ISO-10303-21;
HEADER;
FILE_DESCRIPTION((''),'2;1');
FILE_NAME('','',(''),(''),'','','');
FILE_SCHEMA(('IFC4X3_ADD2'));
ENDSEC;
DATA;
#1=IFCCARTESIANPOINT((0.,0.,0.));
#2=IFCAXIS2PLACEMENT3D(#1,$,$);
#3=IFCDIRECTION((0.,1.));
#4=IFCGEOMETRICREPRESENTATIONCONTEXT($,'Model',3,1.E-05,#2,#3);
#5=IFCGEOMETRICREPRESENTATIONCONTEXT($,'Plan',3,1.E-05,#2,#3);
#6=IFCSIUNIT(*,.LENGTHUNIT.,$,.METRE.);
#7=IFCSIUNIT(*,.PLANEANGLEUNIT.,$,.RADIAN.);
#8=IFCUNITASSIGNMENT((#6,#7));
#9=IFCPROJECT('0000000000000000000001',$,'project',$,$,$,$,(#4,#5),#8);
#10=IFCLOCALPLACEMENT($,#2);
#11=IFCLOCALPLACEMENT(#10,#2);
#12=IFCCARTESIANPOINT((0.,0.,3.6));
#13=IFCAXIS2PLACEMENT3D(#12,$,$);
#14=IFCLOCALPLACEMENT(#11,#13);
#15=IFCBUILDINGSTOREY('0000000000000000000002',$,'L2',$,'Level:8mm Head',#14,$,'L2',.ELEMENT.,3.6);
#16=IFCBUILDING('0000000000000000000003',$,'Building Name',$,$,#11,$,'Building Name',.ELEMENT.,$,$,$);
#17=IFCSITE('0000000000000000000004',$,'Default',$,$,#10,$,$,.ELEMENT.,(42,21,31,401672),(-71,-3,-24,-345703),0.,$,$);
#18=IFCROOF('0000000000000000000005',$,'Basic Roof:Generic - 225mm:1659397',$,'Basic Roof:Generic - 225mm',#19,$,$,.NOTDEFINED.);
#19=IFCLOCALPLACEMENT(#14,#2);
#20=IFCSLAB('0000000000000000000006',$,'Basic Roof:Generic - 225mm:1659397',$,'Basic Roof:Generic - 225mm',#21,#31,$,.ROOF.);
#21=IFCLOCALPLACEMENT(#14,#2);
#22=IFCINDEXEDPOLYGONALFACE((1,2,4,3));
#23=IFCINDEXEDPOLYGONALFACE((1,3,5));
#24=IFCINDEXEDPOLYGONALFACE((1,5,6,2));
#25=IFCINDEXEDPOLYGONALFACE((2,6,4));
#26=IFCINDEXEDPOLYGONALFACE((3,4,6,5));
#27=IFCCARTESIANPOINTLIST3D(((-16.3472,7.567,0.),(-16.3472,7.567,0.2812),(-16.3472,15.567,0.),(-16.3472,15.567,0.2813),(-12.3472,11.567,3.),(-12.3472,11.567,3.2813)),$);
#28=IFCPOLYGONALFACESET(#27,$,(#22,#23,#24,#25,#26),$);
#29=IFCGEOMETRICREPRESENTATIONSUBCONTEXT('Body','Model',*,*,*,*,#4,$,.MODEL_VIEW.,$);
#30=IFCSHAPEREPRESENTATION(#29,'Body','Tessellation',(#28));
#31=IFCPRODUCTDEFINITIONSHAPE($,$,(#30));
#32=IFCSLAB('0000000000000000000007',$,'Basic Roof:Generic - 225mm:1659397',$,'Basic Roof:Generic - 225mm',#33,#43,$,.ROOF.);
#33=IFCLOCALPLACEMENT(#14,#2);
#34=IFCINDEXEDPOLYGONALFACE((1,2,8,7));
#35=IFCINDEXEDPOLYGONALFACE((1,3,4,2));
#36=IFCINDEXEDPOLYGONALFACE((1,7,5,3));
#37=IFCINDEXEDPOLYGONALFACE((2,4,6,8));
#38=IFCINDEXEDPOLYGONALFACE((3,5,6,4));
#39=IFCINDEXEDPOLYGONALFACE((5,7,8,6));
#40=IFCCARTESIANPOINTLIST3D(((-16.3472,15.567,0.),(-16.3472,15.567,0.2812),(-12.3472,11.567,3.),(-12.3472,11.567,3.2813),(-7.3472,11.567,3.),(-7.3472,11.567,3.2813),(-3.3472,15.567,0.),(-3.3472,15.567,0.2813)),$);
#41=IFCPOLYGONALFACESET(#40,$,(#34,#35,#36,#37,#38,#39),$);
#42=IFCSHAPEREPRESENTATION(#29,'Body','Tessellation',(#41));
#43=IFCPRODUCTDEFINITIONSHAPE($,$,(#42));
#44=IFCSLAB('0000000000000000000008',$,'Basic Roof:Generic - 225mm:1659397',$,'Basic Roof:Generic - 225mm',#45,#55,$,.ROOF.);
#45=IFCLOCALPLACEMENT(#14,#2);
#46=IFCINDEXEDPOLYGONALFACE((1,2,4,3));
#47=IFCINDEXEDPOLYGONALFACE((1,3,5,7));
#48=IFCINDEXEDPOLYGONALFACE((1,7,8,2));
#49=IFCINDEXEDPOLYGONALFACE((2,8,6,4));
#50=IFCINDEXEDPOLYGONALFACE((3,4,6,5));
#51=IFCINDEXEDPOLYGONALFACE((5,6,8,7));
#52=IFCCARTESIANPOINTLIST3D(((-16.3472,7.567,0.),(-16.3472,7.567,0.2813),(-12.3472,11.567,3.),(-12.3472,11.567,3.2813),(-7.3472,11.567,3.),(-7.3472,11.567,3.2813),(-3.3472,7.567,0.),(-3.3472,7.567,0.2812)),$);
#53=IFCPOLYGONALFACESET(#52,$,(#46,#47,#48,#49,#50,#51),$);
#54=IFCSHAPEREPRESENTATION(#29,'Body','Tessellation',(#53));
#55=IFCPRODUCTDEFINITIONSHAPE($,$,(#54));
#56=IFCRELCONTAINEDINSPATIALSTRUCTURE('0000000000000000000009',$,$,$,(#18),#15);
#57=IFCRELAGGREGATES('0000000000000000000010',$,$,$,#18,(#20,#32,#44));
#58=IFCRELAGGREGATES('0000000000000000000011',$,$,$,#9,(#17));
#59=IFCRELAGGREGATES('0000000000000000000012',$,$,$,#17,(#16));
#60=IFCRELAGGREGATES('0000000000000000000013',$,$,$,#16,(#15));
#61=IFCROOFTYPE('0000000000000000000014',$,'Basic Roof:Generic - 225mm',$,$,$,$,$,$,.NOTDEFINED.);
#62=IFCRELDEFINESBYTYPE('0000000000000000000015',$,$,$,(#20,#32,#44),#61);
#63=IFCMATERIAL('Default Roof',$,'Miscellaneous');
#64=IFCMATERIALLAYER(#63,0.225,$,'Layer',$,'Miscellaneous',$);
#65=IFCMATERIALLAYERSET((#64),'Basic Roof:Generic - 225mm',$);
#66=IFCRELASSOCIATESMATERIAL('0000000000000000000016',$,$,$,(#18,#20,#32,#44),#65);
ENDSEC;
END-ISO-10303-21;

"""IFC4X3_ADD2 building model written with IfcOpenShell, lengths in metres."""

from ifc_helpers import new_model, si_unit, direction, frame, origin, place, context, subcontext, project, spatial, polyline, outline, extrude, material, layer, layer_set, type_object, element, aggregate, save


model = new_model("IFC4X3_ADD2")

# Units and contexts
model_context = context("Model", 3, precision=1e-05, world=origin(), true_north=direction((0.0, 1.0)))
plan_context = context("Plan", 3, precision=1e-05, world=origin(), true_north=direction((0.0, 1.0)))
body_context = subcontext(model_context, "Body", "Model", "MODEL_VIEW")
ifc_project = project(units=[si_unit("LENGTHUNIT", "METRE"), si_unit("PLANEANGLEUNIT", "RADIAN")], contexts=[model_context, plan_context])

# Site, building, storey
site_placement = place(None, origin())
site = spatial("IfcSite", under=ifc_project, at=site_placement, Name="Default", CompositionType="ELEMENT", RefLatitude=(42, 21, 31, 401672), RefLongitude=(-71, -3, -24, -345703), RefElevation=0.0)
building_placement = place(site_placement, origin())
building = spatial("IfcBuilding", under=site, at=building_placement, Name="Building Name", LongName="Building Name", CompositionType="ELEMENT")
storey_placement = place(building_placement, frame((0.0, 0.0, 3.6)))
storey = spatial("IfcBuildingStorey", under=building, at=storey_placement, Name="L2", ObjectType="Level:8mm Head", LongName="L2", CompositionType="ELEMENT", Elevation=3.6)

# Roof, slabs
ifc_material = material(Name="Default Roof", Category="Miscellaneous")
ifc_layer = layer(ifc_material, 0.225, Name="Layer", Category="Miscellaneous")
ifc_layer_set = layer_set([ifc_layer], Name="Basic Roof:Generic - 225mm")
roof_placement = place(storey_placement, frame((-16.3472, 7.567, 0.0)))
roof = element("IfcRoof", 1, at=roof_placement, inside=storey, material=ifc_layer_set, Name="Basic Roof:Generic - 225mm:1659397", ObjectType="Basic Roof:Generic - 225mm", PredefinedType="NOTDEFINED")
roof_type = type_object("IfcRoofType", Name="Basic Roof:Generic - 225mm", PredefinedType="NOTDEFINED")
slab_1_placement = place(roof_placement, origin())
slab_1 = element("IfcSlab", 2, at=slab_1_placement, type_object=roof_type, material=ifc_layer_set, Name="Basic Roof:Generic - 225mm:1659397", ObjectType="Basic Roof:Generic - 225mm", PredefinedType="ROOF", context=body_context, shape_type="SweptSolid", body=[
    extrude(outline(polyline([(-2.5, 4.0), (-2.5, -4.0), (2.5, 0.0), (-2.5, 4.0)])), frame((2.0, 4.0, 1.5), z_axis=(-0.6, 0.0, 0.8), x_axis=(0.8, 0.0, 0.6)), (0.6, 0.0, 0.8), 0.2813),
])
slab_2_placement = place(roof_placement, origin())
slab_2 = element("IfcSlab", 3, at=slab_2_placement, type_object=roof_type, material=ifc_layer_set, Name="Basic Roof:Generic - 225mm:1659397", ObjectType="Basic Roof:Generic - 225mm", PredefinedType="ROOF", context=body_context, shape_type="SweptSolid", body=[
    extrude(outline(polyline([(-2.5, -2.5), (2.5, -2.5), (6.5, 2.5), (-6.5, 2.5), (-2.5, -2.5)])), frame((6.5, 6.0, 1.5), z_axis=(0.0, 0.6, 0.8), x_axis=(1.0, 0.0, 0.0)), (0.0, -0.6, 0.8), 0.2813),
])
slab_3_placement = place(roof_placement, origin())
slab_3 = element("IfcSlab", 4, at=slab_3_placement, type_object=roof_type, material=ifc_layer_set, Name="Basic Roof:Generic - 225mm:1659397", ObjectType="Basic Roof:Generic - 225mm", PredefinedType="ROOF", context=body_context, shape_type="SweptSolid", body=[
    extrude(outline(polyline([(-6.5, -2.5), (6.5, -2.5), (2.5, 2.5), (-2.5, 2.5), (-6.5, -2.5)])), frame((6.5, 2.0, 1.5), z_axis=(0.0, -0.6, 0.8), x_axis=(1.0, 0.0, 0.0)), (0.0, 0.6, 0.8), 0.2813),
])
aggregate(roof, [slab_1, slab_2, slab_3])

save(model, "model.ifc")
